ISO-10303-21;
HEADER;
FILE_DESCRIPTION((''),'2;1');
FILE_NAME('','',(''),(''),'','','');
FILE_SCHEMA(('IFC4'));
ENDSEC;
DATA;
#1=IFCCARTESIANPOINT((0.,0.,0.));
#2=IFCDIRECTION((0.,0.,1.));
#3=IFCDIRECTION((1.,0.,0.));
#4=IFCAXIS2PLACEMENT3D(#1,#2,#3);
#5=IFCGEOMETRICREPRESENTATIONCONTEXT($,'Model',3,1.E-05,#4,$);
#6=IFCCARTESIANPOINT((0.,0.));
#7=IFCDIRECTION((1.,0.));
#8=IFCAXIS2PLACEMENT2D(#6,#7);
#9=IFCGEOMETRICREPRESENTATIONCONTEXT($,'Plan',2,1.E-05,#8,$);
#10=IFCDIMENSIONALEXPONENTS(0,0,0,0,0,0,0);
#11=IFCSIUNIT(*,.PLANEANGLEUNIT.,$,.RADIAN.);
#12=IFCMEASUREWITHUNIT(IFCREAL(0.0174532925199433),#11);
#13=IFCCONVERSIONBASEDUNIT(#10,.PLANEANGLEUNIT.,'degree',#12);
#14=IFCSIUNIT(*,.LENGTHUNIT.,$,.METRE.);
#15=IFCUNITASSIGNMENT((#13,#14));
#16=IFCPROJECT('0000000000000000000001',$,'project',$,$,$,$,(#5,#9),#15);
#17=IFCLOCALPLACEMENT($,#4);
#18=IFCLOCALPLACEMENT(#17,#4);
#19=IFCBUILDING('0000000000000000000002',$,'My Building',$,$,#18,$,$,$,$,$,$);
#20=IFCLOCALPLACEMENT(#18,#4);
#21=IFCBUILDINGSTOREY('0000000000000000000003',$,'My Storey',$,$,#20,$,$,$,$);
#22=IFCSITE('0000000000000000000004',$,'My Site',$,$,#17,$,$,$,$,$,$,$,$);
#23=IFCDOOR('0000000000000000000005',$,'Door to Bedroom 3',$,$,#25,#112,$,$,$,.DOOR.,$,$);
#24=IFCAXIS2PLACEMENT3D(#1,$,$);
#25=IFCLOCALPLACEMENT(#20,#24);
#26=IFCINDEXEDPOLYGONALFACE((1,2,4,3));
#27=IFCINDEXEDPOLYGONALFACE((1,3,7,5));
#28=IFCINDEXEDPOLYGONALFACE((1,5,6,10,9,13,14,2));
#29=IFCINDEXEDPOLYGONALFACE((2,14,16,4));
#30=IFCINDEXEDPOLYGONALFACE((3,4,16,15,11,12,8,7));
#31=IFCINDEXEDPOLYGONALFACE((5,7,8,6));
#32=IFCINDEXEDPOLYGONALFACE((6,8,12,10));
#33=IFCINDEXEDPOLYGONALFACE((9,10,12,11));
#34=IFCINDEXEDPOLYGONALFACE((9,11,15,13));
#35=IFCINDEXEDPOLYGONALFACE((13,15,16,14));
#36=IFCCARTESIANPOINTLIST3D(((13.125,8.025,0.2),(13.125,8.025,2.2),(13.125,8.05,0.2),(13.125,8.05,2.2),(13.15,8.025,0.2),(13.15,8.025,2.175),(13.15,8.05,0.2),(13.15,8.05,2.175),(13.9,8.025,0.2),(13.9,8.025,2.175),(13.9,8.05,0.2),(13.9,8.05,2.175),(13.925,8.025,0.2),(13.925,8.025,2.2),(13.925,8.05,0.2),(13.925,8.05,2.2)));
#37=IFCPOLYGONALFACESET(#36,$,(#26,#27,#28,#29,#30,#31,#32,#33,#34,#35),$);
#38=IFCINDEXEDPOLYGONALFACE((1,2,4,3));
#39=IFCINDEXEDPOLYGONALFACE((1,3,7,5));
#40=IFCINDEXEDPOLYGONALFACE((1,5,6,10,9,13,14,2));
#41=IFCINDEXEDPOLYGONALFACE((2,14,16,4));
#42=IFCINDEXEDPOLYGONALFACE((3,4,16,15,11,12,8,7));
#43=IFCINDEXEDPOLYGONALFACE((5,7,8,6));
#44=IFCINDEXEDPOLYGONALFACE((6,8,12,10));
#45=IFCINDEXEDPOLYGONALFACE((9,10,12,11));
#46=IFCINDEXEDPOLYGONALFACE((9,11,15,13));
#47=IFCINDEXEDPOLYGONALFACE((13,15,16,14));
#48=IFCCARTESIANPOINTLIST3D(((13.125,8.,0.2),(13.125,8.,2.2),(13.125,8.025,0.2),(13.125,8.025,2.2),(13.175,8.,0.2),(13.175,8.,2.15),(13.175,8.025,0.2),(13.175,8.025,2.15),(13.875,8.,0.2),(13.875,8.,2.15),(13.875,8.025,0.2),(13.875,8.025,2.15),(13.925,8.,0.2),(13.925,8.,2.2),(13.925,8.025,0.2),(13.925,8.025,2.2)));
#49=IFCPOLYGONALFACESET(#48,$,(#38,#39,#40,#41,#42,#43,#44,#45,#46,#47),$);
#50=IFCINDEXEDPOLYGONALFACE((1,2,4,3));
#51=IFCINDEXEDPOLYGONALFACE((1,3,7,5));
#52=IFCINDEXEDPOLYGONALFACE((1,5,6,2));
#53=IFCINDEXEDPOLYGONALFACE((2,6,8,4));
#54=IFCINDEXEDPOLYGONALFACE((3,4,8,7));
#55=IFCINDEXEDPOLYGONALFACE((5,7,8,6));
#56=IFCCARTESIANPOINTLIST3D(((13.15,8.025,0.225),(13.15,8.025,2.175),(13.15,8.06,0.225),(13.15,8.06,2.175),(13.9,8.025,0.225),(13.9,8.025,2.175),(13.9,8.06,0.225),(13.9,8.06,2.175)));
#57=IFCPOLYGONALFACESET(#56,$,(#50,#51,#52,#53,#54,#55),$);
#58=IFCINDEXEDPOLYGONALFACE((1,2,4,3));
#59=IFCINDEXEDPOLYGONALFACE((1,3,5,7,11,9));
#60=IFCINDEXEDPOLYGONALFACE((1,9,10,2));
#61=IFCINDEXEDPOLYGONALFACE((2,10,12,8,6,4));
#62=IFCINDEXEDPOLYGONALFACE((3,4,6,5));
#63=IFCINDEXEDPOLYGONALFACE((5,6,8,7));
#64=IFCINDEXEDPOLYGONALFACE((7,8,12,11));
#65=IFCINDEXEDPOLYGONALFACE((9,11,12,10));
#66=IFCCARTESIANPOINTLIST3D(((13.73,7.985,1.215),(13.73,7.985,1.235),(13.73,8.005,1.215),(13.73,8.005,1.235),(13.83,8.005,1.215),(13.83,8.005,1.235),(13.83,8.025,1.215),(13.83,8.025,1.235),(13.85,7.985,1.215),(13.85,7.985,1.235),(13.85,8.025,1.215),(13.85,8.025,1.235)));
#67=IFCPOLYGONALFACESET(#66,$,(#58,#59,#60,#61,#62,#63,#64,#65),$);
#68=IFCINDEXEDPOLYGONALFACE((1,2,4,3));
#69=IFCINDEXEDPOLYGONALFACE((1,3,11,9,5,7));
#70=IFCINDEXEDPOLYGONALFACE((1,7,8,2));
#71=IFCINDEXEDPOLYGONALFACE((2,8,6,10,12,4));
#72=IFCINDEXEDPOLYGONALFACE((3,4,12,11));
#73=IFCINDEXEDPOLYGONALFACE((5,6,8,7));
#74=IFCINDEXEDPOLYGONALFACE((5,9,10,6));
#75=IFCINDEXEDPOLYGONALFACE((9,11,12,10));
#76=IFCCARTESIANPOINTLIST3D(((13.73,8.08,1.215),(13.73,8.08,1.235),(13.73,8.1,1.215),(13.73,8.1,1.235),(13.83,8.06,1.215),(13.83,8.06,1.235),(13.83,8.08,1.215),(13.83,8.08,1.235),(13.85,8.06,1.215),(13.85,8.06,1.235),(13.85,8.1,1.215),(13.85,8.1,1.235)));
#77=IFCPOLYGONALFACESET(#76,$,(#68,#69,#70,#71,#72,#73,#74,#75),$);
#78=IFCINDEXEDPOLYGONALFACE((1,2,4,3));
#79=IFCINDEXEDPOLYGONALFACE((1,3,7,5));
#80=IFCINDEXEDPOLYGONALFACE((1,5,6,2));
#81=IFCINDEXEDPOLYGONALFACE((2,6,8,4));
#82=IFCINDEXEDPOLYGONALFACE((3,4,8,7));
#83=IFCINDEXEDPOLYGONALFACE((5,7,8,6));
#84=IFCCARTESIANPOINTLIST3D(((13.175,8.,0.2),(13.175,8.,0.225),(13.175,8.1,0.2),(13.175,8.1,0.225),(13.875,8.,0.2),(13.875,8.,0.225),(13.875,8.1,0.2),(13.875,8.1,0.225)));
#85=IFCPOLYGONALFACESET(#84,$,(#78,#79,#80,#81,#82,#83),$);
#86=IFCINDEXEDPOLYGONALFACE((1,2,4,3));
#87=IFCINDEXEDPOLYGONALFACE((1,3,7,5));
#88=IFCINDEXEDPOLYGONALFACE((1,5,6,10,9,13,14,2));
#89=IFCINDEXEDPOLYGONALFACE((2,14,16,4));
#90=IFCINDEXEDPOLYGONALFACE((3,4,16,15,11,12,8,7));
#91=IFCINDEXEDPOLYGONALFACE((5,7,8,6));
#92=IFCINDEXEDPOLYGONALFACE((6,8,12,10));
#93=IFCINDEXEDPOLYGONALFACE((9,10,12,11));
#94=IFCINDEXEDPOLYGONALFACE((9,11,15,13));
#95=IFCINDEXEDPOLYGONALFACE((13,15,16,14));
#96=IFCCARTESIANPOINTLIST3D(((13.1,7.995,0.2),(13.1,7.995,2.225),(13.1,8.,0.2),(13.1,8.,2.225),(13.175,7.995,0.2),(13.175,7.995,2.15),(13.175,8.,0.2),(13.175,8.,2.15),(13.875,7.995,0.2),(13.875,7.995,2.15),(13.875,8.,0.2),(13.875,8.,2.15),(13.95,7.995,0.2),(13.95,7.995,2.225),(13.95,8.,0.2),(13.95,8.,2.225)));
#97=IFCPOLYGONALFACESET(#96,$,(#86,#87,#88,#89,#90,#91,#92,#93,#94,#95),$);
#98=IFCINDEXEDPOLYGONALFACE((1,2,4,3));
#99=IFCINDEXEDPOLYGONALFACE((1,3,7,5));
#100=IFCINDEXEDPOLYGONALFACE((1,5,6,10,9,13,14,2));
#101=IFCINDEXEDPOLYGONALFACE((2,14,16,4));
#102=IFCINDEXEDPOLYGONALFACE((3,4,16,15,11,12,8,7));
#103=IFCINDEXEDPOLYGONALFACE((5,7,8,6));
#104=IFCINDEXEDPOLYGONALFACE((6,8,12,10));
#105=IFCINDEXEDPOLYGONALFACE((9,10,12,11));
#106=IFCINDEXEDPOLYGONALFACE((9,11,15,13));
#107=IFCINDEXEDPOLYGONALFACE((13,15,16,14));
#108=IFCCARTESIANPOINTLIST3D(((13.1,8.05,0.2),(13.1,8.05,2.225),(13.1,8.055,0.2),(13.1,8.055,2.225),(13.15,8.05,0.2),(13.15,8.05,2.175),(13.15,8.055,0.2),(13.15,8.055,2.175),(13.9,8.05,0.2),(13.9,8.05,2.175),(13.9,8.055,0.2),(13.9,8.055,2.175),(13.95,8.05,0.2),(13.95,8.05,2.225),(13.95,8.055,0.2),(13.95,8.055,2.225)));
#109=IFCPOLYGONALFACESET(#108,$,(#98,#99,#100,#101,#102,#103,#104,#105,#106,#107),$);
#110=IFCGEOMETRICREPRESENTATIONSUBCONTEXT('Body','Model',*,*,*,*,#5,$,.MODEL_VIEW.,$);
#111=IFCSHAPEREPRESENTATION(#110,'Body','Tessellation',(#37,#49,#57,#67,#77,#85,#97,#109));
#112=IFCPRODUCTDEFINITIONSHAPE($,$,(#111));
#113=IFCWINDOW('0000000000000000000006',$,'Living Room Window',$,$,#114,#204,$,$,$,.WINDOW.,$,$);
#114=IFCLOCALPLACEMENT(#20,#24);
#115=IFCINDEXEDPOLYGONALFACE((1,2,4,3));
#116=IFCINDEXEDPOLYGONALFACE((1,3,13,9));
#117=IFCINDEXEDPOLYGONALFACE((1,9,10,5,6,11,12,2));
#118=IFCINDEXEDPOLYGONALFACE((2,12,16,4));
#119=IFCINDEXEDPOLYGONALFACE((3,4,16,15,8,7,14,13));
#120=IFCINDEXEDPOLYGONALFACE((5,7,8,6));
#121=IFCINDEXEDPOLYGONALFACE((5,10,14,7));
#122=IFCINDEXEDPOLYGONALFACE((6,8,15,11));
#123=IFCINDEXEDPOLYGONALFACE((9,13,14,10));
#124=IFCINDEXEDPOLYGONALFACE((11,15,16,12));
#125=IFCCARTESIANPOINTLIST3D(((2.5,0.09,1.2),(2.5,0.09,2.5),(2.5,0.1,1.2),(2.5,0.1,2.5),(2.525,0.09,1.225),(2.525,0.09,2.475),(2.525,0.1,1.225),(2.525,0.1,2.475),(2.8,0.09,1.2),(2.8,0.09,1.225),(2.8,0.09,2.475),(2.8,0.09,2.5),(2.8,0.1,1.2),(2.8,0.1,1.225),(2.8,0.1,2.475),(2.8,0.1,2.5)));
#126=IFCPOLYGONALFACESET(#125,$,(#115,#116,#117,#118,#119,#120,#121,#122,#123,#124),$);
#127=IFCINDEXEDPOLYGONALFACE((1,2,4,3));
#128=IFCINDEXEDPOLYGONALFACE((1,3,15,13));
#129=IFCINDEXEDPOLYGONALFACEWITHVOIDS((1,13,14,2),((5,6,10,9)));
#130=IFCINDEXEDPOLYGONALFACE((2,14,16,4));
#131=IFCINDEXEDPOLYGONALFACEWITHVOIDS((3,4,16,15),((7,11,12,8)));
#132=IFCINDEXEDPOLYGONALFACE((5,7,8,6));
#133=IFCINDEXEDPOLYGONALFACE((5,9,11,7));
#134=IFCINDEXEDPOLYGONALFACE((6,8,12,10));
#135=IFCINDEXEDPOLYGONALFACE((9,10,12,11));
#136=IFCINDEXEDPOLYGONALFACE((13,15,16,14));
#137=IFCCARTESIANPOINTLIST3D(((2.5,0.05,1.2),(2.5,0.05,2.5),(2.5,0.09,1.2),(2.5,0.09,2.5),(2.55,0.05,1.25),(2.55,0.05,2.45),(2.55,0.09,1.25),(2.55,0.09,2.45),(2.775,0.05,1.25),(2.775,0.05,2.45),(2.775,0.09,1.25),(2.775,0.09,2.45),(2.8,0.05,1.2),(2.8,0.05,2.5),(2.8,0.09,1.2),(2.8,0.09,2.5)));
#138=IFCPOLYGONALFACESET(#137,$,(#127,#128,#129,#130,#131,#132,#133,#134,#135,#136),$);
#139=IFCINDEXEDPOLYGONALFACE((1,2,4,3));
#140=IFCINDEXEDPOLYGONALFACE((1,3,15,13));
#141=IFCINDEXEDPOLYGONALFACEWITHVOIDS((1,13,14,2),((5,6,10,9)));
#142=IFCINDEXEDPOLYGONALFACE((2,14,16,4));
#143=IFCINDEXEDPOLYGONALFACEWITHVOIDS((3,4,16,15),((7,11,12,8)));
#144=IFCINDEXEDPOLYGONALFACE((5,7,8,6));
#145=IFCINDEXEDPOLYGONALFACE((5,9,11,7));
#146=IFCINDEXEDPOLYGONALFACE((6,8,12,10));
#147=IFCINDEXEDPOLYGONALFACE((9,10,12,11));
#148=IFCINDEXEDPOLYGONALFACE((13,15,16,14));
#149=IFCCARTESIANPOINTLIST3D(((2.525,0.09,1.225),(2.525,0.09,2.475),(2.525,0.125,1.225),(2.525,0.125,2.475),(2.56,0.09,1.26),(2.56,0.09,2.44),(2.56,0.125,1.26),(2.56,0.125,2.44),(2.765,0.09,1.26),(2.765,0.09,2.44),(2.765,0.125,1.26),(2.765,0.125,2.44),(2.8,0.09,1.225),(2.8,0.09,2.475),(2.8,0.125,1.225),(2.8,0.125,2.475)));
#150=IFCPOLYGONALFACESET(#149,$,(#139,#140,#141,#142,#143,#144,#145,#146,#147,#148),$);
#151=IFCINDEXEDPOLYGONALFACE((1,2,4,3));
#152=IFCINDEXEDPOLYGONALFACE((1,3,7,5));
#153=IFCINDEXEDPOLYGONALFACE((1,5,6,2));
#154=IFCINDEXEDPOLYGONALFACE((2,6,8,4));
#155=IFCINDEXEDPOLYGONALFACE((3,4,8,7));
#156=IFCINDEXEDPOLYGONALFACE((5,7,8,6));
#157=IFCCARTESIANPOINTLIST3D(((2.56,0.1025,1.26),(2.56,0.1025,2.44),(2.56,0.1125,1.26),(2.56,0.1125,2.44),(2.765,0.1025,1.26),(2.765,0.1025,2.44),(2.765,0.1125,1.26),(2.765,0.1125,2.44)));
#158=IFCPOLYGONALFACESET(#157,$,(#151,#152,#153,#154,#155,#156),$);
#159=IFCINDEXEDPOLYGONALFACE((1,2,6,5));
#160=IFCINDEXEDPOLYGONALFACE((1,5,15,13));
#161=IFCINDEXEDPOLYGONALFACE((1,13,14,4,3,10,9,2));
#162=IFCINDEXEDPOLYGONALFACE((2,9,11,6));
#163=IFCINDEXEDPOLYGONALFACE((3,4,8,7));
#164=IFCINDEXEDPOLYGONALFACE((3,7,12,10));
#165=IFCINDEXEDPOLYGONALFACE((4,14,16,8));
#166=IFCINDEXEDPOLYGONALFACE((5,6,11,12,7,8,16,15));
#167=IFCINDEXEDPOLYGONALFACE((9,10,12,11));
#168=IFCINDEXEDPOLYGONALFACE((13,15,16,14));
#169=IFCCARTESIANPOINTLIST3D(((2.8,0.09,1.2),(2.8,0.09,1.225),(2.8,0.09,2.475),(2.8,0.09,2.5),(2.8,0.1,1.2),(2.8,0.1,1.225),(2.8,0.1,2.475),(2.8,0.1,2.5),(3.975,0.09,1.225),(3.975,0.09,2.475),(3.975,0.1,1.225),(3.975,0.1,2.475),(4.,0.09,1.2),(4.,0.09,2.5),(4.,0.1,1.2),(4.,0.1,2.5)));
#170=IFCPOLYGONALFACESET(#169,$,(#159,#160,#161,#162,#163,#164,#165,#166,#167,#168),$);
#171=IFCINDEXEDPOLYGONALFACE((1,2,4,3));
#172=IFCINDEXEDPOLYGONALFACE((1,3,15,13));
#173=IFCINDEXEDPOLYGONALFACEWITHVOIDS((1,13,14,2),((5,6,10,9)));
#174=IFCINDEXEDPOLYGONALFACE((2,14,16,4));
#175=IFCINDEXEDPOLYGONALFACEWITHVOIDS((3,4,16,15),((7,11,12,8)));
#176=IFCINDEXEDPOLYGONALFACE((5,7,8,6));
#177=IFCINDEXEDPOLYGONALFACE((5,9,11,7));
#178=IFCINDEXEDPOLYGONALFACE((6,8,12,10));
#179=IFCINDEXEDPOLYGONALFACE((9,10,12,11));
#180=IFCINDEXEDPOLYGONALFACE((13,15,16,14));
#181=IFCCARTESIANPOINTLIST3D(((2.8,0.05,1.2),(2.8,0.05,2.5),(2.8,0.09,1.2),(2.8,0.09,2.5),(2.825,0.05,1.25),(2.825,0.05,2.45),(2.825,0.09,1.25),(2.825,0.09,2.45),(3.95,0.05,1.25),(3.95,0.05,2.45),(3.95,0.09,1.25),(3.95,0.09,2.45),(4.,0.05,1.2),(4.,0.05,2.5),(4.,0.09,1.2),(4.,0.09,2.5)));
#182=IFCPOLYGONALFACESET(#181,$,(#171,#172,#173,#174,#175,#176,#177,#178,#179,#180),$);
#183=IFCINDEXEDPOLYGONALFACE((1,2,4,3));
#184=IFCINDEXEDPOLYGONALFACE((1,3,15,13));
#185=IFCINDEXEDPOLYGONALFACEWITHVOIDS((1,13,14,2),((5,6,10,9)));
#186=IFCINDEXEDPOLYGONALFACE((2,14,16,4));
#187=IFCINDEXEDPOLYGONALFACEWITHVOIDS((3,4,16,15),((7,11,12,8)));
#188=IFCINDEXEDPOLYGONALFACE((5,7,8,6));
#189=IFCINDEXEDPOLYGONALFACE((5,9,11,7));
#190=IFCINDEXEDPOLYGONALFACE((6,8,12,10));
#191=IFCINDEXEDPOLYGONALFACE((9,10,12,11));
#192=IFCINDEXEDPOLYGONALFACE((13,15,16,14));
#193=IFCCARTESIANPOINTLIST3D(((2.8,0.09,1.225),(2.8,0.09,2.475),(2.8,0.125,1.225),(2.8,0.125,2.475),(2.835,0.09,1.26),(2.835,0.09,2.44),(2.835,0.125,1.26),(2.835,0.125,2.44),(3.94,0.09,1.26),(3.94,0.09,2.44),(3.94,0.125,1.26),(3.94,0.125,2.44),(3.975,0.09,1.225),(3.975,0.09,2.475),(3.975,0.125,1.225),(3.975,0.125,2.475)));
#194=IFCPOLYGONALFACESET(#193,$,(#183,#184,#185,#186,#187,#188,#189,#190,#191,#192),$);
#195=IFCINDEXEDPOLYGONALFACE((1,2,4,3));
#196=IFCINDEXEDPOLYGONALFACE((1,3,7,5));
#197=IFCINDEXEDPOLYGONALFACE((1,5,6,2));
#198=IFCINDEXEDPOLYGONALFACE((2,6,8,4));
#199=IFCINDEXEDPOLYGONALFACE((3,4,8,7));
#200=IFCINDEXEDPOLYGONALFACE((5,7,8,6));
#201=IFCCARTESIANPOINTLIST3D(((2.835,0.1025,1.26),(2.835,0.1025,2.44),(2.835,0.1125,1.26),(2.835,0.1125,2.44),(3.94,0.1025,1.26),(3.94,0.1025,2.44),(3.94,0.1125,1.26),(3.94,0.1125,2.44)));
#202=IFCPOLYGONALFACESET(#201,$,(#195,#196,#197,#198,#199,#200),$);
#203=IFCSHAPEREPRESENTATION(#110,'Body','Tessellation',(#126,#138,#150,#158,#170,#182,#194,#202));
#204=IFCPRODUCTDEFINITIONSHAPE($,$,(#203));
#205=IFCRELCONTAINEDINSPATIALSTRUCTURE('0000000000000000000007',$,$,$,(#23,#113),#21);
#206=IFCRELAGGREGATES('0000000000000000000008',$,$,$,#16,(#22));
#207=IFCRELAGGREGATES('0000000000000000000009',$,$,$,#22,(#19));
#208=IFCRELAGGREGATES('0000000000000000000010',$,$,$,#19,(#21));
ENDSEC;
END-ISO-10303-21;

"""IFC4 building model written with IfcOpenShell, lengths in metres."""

from ifc_helpers import new_model, entity, si_unit, converted_unit, frame, origin_with_axes, origin_2d_with_axis, place, context, subcontext, project, spatial, line, indexed_curve, outline, extrude, element, save


model = new_model("IFC4")

# Units and contexts
model_context = context("Model", 3, precision=1e-05, world=origin_with_axes())
plan_context = context("Plan", 2, precision=1e-05, world=origin_2d_with_axis())
body_context = subcontext(model_context, "Body", "Model", "MODEL_VIEW")
ifc_project = project(units=[converted_unit("PLANEANGLEUNIT", "degree", entity("IfcReal", 0.0174532925199433), si_unit("PLANEANGLEUNIT", "RADIAN"), dimensions=[0, 0, 0, 0, 0, 0, 0]), si_unit("LENGTHUNIT", "METRE")], contexts=[model_context, plan_context])

# Site, building, storey
site_placement = place(None, origin_with_axes())
site = spatial("IfcSite", under=ifc_project, at=site_placement, Name="My Site")
building_placement = place(site_placement, origin_with_axes())
building = spatial("IfcBuilding", under=site, at=building_placement, Name="My Building")
storey_placement = place(building_placement, origin_with_axes())
storey = spatial("IfcBuildingStorey", under=building, at=storey_placement, Name="My Storey")

# Door
door_1_placement = place(storey_placement, frame((13.125, 8.0, 0.2), z_axis=(0.0, 0.0, 1.0), x_axis=(1.0, 0.0, 0.0)))
element("IfcDoor", 1, at=door_1_placement, inside=storey, Name="Door to Bedroom 3", PredefinedType="DOOR", context=body_context, shape_type="SweptSolid", body=[
    extrude(outline(indexed_curve([(0.0, 0.0), (0.0, 2.0), (0.8, 2.0), (0.8, 0.0), (0.775, 0.0), (0.775, 1.975), (0.025, 1.975), (0.025, 0.0)], segments=[line(1, 2, 3, 4, 5, 6, 7, 8, 1)])), frame((0.0, 0.025, 0.0), z_axis=(0.0, -1.0, 0.0), x_axis=(1.0, 0.0, 0.0)), (0.0, 0.0, -1.0), 0.025),
    extrude(outline(indexed_curve([(0.0, 0.0), (0.0, 2.0), (0.8, 2.0), (0.8, 0.0), (0.75, 0.0), (0.75, 1.95), (0.05, 1.95), (0.05, 0.0)], segments=[line(1, 2, 3, 4, 5, 6, 7, 8, 1)])), frame((0.0, 0.0, 0.0), z_axis=(0.0, -1.0, 0.0), x_axis=(1.0, 0.0, 0.0)), (0.0, 0.0, -1.0), 0.025),
    extrude(outline(indexed_curve([(0.0, 0.0), (0.75, 0.0), (0.75, 0.035), (0.0, 0.035)], segments=[line(1, 2, 3, 4, 1)])), frame((0.025, 0.025, 0.025), z_axis=(0.0, 0.0, 1.0), x_axis=(1.0, 0.0, 0.0)), (0.0, 0.0, 1.0), 1.95),
    extrude(outline(indexed_curve([(0.0, 0.0), (0.0, -0.04), (-0.12, -0.04), (-0.12, -0.02), (-0.02, -0.02), (-0.02, 0.0)], segments=[line(1, 2, 3, 4, 5, 6, 1)])), frame((0.725, 0.025, 1.015), z_axis=(0.0, 0.0, 1.0), x_axis=(1.0, 0.0, 0.0)), (0.0, 0.0, 1.0), 0.02),
    extrude(outline(indexed_curve([(0.0, 0.0), (0.0, 0.04), (-0.12, 0.04), (-0.12, 0.02), (-0.02, 0.02), (-0.02, 0.0)], segments=[line(1, 2, 3, 4, 5, 6, 1)])), frame((0.725, 0.06, 1.015), z_axis=(0.0, 0.0, 1.0), x_axis=(1.0, 0.0, 0.0)), (0.0, 0.0, 1.0), 0.02),
    extrude(outline(indexed_curve([(0.0, 0.0), (0.7, 0.0), (0.7, 0.1), (0.0, 0.1)], segments=[line(1, 2, 3, 4, 1)])), frame((0.05, 0.0, 0.0), z_axis=(0.0, 0.0, 1.0), x_axis=(1.0, 0.0, 0.0)), (0.0, 0.0, 1.0), 0.025),
    extrude(outline(indexed_curve([(0.0, 0.0), (0.0, 2.025), (0.85, 2.025), (0.85, 0.0), (0.775, 0.0), (0.775, 1.95), (0.075, 1.95), (0.075, 0.0)], segments=[line(1, 2, 3, 4, 5, 6, 7, 8, 1)])), frame((-0.025, -0.005, 0.0), z_axis=(0.0, -1.0, 0.0), x_axis=(1.0, 0.0, 0.0)), (0.0, 0.0, -1.0), 0.005),
    extrude(outline(indexed_curve([(0.0, 0.0), (0.0, 2.025), (0.85, 2.025), (0.85, 0.0), (0.8, 0.0), (0.8, 1.975), (0.05, 1.975), (0.05, 0.0)], segments=[line(1, 2, 3, 4, 5, 6, 7, 8, 1)])), frame((-0.025, 0.05, 0.0), z_axis=(0.0, -1.0, 0.0), x_axis=(1.0, 0.0, 0.0)), (0.0, 0.0, -1.0), 0.005),
])

# Window
window_placement = place(storey_placement, frame((2.5, 0.0, 1.2), z_axis=(0.0, 0.0, 1.0), x_axis=(1.0, 0.0, 0.0)))
element("IfcWindow", 2, at=window_placement, inside=storey, Name="Living Room Window", PredefinedType="WINDOW", context=body_context, shape_type="SweptSolid", body=[
    extrude(outline(indexed_curve([(0.3, 0.0), (0.0, 0.0), (0.0, 1.3), (0.3, 1.3), (0.3, 1.275), (0.025, 1.275), (0.025, 0.025), (0.3, 0.025)], segments=[line(1, 2, 3, 4, 5, 6, 7, 8, 1)])), frame((0.0, 0.09, 0.0), z_axis=(0.0, -1.0, 0.0), x_axis=(1.0, 0.0, 0.0)), (0.0, 0.0, -1.0), 0.01),
    extrude(outline(indexed_curve([(0.0, 0.0), (0.3, 0.0), (0.3, 1.3), (0.0, 1.3)], segments=[line(1, 2, 3, 4, 1)]), holes=[indexed_curve([(0.05, 0.05), (0.275, 0.05), (0.275, 1.25), (0.05, 1.25)], segments=[line(1, 2, 3, 4, 1)])]), frame((0.0, 0.05, 0.0), z_axis=(0.0, -1.0, 0.0), x_axis=(1.0, 0.0, 0.0)), (0.0, 0.0, -1.0), 0.04),
    extrude(outline(indexed_curve([(0.0, 0.0), (0.275, 0.0), (0.275, 1.25), (0.0, 1.25)], segments=[line(1, 2, 3, 4, 1)]), holes=[indexed_curve([(0.035, 0.035), (0.24, 0.035), (0.24, 1.215), (0.035, 1.215)], segments=[line(1, 2, 3, 4, 1)])]), frame((0.025, 0.09, 0.025), z_axis=(0.0, -1.0, 0.0), x_axis=(1.0, 0.0, 0.0)), (0.0, 0.0, -1.0), 0.035),
    extrude(outline(indexed_curve([(0.035, 0.035), (0.24, 0.035), (0.24, 1.215), (0.035, 1.215)], segments=[line(1, 2, 3, 4, 1)])), frame((0.025, 0.1025, 0.025), z_axis=(0.0, -1.0, 0.0), x_axis=(1.0, 0.0, 0.0)), (0.0, 0.0, -1.0), 0.01),
    extrude(outline(indexed_curve([(0.0, 1.3), (1.2, 1.3), (1.2, 0.0), (0.0, 0.0), (0.0, 0.025), (1.175, 0.025), (1.175, 1.275), (0.0, 1.275)], segments=[line(1, 2, 3, 4, 5, 6, 7, 8, 1)])), frame((0.3, 0.09, 0.0), z_axis=(0.0, -1.0, 0.0), x_axis=(1.0, 0.0, 0.0)), (0.0, 0.0, -1.0), 0.01),
    extrude(outline(indexed_curve([(0.0, 0.0), (1.2, 0.0), (1.2, 1.3), (0.0, 1.3)], segments=[line(1, 2, 3, 4, 1)]), holes=[indexed_curve([(0.025, 0.05), (1.15, 0.05), (1.15, 1.25), (0.025, 1.25)], segments=[line(1, 2, 3, 4, 1)])]), frame((0.3, 0.05, 0.0), z_axis=(0.0, -1.0, 0.0), x_axis=(1.0, 0.0, 0.0)), (0.0, 0.0, -1.0), 0.04),
    extrude(outline(indexed_curve([(0.0, 0.0), (1.175, 0.0), (1.175, 1.25), (0.0, 1.25)], segments=[line(1, 2, 3, 4, 1)]), holes=[indexed_curve([(0.035, 0.035), (1.14, 0.035), (1.14, 1.215), (0.035, 1.215)], segments=[line(1, 2, 3, 4, 1)])]), frame((0.3, 0.09, 0.025), z_axis=(0.0, -1.0, 0.0), x_axis=(1.0, 0.0, 0.0)), (0.0, 0.0, -1.0), 0.035),
    extrude(outline(indexed_curve([(0.035, 0.035), (1.14, 0.035), (1.14, 1.215), (0.035, 1.215)], segments=[line(1, 2, 3, 4, 1)])), frame((0.3, 0.1025, 0.025), z_axis=(0.0, -1.0, 0.0), x_axis=(1.0, 0.0, 0.0)), (0.0, 0.0, -1.0), 0.01),
])

save(model, "model.ifc")
